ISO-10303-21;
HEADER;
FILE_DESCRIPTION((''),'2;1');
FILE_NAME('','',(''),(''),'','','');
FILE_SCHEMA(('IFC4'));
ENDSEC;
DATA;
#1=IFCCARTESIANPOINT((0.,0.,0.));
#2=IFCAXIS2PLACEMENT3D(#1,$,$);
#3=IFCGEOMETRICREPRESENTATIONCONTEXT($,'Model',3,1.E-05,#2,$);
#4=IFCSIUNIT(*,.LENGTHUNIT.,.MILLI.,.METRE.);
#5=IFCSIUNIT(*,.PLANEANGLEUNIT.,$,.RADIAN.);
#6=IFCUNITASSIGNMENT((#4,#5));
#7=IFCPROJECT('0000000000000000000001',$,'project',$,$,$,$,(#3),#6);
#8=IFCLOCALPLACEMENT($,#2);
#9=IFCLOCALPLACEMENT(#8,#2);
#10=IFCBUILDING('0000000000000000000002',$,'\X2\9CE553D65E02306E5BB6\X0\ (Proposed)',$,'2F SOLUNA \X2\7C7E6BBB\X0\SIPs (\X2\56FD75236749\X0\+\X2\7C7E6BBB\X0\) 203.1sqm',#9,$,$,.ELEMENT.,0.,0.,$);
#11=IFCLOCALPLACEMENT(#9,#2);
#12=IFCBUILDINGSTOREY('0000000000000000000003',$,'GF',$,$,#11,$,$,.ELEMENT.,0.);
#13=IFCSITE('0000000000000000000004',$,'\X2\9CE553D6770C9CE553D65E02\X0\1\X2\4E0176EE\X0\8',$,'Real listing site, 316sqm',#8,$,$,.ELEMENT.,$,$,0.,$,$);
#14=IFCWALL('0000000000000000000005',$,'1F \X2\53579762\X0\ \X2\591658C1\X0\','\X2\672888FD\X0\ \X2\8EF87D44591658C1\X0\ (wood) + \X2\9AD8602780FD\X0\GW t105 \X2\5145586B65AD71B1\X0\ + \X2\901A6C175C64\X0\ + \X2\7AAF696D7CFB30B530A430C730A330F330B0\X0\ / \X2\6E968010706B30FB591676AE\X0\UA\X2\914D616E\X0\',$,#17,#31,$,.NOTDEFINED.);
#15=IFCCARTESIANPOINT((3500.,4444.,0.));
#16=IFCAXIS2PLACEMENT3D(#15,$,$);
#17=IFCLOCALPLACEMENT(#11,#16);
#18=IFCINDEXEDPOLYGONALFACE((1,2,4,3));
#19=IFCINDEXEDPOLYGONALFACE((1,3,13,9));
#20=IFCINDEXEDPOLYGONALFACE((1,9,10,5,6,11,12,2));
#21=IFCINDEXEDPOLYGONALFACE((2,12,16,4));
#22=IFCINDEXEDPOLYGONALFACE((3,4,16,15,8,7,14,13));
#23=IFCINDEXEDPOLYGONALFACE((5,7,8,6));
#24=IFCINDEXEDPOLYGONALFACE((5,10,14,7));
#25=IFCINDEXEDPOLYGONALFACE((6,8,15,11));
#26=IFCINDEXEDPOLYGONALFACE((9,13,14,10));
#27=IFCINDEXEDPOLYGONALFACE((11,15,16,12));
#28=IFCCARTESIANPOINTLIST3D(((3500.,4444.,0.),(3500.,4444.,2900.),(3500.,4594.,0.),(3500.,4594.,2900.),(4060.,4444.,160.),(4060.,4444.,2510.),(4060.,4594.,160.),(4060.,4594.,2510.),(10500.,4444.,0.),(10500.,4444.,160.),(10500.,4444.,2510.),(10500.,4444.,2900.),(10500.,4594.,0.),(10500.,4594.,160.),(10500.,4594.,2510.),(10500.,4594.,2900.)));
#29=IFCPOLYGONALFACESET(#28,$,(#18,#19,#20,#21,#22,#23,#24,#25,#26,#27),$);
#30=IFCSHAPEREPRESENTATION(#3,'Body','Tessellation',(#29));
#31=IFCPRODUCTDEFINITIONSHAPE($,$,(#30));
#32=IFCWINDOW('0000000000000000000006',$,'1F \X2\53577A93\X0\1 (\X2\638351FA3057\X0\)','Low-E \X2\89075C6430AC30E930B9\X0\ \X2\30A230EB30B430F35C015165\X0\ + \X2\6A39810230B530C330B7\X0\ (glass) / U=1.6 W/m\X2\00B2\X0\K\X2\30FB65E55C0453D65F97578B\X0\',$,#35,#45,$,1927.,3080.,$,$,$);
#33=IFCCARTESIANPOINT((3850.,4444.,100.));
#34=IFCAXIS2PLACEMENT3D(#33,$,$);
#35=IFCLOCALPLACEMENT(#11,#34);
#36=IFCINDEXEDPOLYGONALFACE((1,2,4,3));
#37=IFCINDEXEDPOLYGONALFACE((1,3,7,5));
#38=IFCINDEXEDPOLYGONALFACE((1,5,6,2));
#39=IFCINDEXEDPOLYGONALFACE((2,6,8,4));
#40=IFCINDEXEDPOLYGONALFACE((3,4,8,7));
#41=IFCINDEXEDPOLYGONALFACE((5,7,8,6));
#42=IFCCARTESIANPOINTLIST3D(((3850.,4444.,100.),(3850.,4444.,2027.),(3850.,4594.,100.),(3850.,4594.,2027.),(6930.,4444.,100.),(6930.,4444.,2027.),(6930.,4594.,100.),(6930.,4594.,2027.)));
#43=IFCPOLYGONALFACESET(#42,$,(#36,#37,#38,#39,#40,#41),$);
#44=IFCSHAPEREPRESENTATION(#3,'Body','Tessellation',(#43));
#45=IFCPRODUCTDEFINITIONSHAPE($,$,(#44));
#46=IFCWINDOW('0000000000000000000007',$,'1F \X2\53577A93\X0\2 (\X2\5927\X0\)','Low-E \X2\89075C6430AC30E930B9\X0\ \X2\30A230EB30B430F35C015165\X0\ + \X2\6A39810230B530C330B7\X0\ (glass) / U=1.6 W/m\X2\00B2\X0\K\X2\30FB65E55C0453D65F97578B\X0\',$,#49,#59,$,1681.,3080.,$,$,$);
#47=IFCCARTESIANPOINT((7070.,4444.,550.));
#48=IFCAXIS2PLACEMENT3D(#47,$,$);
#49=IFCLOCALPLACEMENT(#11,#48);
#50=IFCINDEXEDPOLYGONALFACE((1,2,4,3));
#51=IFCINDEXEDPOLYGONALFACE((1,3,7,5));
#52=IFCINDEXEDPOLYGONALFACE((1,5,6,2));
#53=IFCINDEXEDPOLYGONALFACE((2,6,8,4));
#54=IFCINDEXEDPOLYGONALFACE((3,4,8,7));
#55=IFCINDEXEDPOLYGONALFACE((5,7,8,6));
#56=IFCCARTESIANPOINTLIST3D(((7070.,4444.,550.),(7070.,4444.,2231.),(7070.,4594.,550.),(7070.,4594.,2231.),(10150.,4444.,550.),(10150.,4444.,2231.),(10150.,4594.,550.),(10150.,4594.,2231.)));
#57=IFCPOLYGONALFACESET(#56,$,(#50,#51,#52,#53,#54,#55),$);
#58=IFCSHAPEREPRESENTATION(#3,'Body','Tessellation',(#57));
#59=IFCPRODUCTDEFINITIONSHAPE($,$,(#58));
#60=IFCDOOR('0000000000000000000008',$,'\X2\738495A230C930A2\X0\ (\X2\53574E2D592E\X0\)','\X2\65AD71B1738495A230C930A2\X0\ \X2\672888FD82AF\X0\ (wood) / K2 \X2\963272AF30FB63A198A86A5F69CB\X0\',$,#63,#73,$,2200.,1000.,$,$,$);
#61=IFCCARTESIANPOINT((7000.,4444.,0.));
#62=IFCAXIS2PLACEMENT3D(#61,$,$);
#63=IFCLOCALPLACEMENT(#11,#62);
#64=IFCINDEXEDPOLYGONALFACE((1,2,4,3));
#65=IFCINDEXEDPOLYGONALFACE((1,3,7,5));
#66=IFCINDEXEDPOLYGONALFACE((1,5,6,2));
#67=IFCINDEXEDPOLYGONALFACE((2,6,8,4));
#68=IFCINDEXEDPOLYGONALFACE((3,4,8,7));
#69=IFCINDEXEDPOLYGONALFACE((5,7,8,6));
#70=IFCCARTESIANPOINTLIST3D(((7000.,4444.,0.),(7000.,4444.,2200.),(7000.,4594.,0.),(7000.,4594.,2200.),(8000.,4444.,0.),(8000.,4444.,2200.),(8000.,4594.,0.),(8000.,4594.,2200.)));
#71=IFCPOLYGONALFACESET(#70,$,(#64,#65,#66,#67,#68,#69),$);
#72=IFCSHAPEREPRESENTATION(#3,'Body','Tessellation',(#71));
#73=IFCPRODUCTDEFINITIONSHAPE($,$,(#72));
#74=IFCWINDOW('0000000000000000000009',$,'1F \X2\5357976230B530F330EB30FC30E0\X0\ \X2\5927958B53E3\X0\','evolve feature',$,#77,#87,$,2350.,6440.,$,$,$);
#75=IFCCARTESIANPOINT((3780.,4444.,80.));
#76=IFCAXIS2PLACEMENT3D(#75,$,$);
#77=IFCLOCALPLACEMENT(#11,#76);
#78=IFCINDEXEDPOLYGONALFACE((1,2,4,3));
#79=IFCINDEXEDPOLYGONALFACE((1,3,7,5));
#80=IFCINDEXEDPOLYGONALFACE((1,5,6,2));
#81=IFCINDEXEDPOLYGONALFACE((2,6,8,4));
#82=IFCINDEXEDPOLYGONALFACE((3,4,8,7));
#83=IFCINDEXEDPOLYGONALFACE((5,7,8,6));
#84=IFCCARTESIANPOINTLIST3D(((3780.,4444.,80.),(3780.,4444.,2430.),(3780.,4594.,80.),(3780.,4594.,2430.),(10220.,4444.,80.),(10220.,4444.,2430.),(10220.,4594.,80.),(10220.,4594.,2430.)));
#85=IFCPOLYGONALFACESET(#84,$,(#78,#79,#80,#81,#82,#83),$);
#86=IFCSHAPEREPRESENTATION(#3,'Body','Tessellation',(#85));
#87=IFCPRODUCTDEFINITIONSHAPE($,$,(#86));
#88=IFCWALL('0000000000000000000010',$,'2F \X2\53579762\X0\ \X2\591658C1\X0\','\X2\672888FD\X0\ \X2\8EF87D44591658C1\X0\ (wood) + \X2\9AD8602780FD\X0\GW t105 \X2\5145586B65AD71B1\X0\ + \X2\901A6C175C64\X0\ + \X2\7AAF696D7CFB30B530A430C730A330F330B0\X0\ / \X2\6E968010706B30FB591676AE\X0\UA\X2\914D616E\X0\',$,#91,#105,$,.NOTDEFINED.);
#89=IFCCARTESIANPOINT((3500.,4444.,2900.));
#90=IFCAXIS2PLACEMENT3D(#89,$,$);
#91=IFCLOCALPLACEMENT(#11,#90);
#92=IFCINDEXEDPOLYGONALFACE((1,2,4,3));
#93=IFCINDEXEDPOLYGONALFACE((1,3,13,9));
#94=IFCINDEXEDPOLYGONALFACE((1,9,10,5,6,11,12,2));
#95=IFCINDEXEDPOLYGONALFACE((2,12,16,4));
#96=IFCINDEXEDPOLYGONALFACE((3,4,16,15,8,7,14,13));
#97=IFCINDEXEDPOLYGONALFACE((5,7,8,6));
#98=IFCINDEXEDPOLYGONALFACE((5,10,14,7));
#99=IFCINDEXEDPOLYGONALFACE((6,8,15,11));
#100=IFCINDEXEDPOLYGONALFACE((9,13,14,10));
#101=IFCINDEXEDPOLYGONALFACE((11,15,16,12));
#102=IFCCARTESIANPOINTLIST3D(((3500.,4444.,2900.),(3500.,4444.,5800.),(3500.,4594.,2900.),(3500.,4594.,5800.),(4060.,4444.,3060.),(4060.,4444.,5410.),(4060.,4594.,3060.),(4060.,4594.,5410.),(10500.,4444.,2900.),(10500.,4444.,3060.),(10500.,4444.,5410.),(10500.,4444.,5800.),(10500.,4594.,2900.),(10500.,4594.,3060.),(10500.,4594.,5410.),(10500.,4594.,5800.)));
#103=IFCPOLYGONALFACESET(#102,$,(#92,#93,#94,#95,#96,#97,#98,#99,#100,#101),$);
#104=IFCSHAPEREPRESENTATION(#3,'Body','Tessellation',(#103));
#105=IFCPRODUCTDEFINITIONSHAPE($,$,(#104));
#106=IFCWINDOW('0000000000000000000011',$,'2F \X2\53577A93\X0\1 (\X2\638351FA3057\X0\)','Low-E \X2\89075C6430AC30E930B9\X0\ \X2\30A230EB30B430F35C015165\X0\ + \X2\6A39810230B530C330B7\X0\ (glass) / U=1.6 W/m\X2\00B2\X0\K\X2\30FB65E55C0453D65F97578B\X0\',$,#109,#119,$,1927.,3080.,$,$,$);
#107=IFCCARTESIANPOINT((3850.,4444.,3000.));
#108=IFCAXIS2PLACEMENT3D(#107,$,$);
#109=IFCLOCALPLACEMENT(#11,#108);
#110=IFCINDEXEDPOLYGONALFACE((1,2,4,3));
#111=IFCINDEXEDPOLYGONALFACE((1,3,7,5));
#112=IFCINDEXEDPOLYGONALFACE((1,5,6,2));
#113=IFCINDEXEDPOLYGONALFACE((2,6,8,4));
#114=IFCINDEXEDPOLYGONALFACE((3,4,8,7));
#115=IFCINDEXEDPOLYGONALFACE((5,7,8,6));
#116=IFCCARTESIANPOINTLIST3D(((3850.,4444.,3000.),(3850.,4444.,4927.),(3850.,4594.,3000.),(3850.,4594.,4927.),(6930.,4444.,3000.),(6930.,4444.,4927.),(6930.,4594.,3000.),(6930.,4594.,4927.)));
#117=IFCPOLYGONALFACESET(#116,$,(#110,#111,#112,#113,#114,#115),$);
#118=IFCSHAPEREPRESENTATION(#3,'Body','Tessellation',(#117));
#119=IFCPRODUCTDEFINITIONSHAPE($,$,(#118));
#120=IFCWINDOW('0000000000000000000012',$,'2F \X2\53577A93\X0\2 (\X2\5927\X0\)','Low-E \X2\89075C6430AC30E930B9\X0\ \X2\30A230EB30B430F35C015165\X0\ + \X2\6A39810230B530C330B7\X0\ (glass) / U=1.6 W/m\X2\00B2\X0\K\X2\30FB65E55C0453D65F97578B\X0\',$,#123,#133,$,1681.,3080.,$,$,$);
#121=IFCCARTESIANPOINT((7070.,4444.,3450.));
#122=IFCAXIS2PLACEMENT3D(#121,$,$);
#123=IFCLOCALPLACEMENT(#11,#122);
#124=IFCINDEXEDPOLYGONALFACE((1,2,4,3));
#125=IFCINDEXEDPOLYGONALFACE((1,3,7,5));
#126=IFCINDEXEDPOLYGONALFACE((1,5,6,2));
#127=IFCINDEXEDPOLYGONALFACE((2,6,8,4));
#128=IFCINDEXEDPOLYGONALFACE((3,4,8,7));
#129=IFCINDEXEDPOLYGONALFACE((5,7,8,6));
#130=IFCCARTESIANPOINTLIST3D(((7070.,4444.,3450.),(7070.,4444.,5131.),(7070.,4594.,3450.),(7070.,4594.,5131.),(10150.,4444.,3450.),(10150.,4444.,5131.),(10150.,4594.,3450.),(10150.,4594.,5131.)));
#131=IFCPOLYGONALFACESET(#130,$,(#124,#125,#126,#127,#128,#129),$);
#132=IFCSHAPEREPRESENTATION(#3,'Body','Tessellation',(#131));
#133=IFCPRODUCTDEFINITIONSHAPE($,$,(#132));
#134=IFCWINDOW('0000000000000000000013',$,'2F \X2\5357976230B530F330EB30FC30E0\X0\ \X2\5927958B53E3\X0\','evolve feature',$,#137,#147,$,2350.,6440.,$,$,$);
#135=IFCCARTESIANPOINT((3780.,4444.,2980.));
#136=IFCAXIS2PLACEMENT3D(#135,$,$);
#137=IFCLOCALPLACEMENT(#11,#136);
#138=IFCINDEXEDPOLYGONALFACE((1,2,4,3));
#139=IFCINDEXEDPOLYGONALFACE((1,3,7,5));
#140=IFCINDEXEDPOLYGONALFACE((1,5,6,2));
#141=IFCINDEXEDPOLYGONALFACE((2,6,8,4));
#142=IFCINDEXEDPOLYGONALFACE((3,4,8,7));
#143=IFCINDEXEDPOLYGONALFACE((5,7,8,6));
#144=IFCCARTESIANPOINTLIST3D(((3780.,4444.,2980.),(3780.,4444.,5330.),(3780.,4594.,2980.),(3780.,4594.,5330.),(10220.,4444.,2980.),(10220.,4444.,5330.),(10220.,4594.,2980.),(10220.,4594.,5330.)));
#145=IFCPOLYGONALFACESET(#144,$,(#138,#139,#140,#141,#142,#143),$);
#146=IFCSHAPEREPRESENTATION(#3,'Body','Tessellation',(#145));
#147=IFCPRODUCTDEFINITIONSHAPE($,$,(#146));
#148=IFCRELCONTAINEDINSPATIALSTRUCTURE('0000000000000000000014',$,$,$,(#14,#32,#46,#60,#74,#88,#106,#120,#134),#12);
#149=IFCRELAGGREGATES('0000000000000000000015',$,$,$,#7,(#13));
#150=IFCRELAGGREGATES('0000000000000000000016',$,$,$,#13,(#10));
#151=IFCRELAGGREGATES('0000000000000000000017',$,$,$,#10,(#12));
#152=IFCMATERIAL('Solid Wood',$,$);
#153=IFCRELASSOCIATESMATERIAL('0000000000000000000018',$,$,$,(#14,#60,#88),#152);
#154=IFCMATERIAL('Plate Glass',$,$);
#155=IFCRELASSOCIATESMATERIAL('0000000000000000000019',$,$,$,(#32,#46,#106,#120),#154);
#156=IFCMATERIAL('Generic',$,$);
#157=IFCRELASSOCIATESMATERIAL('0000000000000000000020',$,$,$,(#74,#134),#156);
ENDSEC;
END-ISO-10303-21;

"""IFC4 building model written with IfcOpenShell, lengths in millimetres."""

from ifc_helpers import new_model, si_unit, frame, frame_2d, origin, place, context, project, spatial, rectangle, extrude, material, element, fill, save


model = new_model("IFC4")

# Units and contexts
model_context = context("Model", 3, precision=1e-05, world=origin())
ifc_project = project(units=[si_unit("LENGTHUNIT", "METRE", prefix="MILLI"), si_unit("PLANEANGLEUNIT", "RADIAN")], contexts=[model_context])

# Site, building, storey
site_placement = place(None, origin())
site = spatial("IfcSite", under=ifc_project, at=site_placement, Name="鳥取県鳥取市1丁目8", ObjectType="Real listing site, 316sqm", CompositionType="ELEMENT", RefElevation=0.0)
building_placement = place(site_placement, origin())
building = spatial("IfcBuilding", under=site, at=building_placement, Name="鳥取市の家 (Proposed)", ObjectType="2F SOLUNA 籾殻SIPs (国産杉+籾殻) 203.1sqm", CompositionType="ELEMENT", ElevationOfRefHeight=0.0, ElevationOfTerrain=0.0)
storey_placement = place(building_placement, origin())
storey = spatial("IfcBuildingStorey", under=building, at=storey_placement, Name="GF", CompositionType="ELEMENT", Elevation=0.0)

# Shared definitions
ifc_material_1 = material(Name="Solid Wood")

# Wall, openings, windows, door
wall_1_placement = place(storey_placement, frame((3500.0, 4444.0, 0.0)))
wall_1 = element("IfcWall", 1, at=wall_1_placement, inside=storey, material=ifc_material_1, Name="1F 南面 外壁", Description="木製 軸組外壁 (wood) + 高性能GW t105 充填断熱 + 通気層 + 窯業系サイディング / 準耐火・外皮UA配慮", PredefinedType="NOTDEFINED", context=model_context, shape_type="SweptSolid", body=[
    extrude(rectangle(XDim=7000.0, YDim=150.0, at=frame_2d((3500.0, 75.0))), frame((3500.0, 4444.0, 0.0)), (0.0, 0.0, 1.0), 2900.0),
])
opening_1_placement = place(storey_placement, frame((3850.0, 4444.0, 100.0)))
opening_1 = element("IfcOpeningElement", 2, at=opening_1_placement, cuts=wall_1, PredefinedType="NOTDEFINED", context=model_context, shape_type="SweptSolid", body=[
    extrude(rectangle(XDim=3080.0, YDim=150.0, at=frame_2d((1540.0, 75.0))), frame((3850.0, 4444.0, 100.0)), (0.0, 0.0, 1.0), 1927.0),
])
opening_2_placement = place(storey_placement, frame((7070.0, 4444.0, 550.0)))
opening_2 = element("IfcOpeningElement", 3, at=opening_2_placement, cuts=wall_1, PredefinedType="NOTDEFINED", context=model_context, shape_type="SweptSolid", body=[
    extrude(rectangle(XDim=3080.0, YDim=150.0, at=frame_2d((1540.0, 75.0))), frame((7070.0, 4444.0, 550.0)), (0.0, 0.0, 1.0), 1681.0),
])
opening_3_placement = place(storey_placement, frame((7000.0, 4444.0, 0.0)))
opening_3 = element("IfcOpeningElement", 4, at=opening_3_placement, cuts=wall_1, PredefinedType="NOTDEFINED", context=model_context, shape_type="SweptSolid", body=[
    extrude(rectangle(XDim=1000.0, YDim=150.0, at=frame_2d((500.0, 75.0))), frame((7000.0, 4444.0, 0.0)), (0.0, 0.0, 1.0), 2200.0),
])
opening_4_placement = place(storey_placement, frame((3780.0, 4444.0, 80.0)))
opening_4 = element("IfcOpeningElement", 5, at=opening_4_placement, cuts=wall_1, PredefinedType="NOTDEFINED", context=model_context, shape_type="SweptSolid", body=[
    extrude(rectangle(XDim=6440.0, YDim=150.0, at=frame_2d((3220.0, 75.0))), frame((3780.0, 4444.0, 80.0)), (0.0, 0.0, 1.0), 2350.0),
])
ifc_material_2 = material(Name="Plate Glass")
window_1_placement = place(storey_placement, frame((3850.0, 4444.0, 100.0)))
window_1 = element("IfcWindow", 6, at=window_1_placement, inside=storey, material=ifc_material_2, Name="1F 南窓1 (掃出し)", Description="Low-E 複層ガラス アルゴン封入 + 樹脂サッシ (glass) / U=1.6 W/m²K・日射取得型", OverallHeight=1927.0, OverallWidth=3080.0, context=model_context, shape_type="SweptSolid", body=[
    extrude(rectangle(XDim=3080.0, YDim=150.0, at=frame_2d((1540.0, 75.0))), frame((3850.0, 4444.0, 100.0)), (0.0, 0.0, 1.0), 1927.0),
])
fill(opening_1, window_1)
window_2_placement = place(storey_placement, frame((7070.0, 4444.0, 550.0)))
window_2 = element("IfcWindow", 7, at=window_2_placement, inside=storey, material=ifc_material_2, Name="1F 南窓2 (大)", Description="Low-E 複層ガラス アルゴン封入 + 樹脂サッシ (glass) / U=1.6 W/m²K・日射取得型", OverallHeight=1681.0, OverallWidth=3080.0, context=model_context, shape_type="SweptSolid", body=[
    extrude(rectangle(XDim=3080.0, YDim=150.0, at=frame_2d((1540.0, 75.0))), frame((7070.0, 4444.0, 550.0)), (0.0, 0.0, 1.0), 1681.0),
])
fill(opening_2, window_2)
door_placement = place(storey_placement, frame((7000.0, 4444.0, 0.0)))
door = element("IfcDoor", 8, at=door_placement, inside=storey, material=ifc_material_1, Name="玄関ドア (南中央)", Description="断熱玄関ドア 木製芯 (wood) / K2 防犯・採風機構", OverallHeight=2200.0, OverallWidth=1000.0, context=model_context, shape_type="SweptSolid", body=[
    extrude(rectangle(XDim=1000.0, YDim=150.0, at=frame_2d((500.0, 75.0))), frame((7000.0, 4444.0, 0.0)), (0.0, 0.0, 1.0), 2200.0),
])
fill(opening_3, door)
ifc_material_3 = material(Name="Generic")
window_3_placement = place(storey_placement, frame((3780.0, 4444.0, 80.0)))
window_3 = element("IfcWindow", 9, at=window_3_placement, inside=storey, material=ifc_material_3, Name="1F 南面サンルーム 大開口", Description="evolve feature", OverallHeight=2350.0, OverallWidth=6440.0, context=model_context, shape_type="SweptSolid", body=[
    extrude(rectangle(XDim=6440.0, YDim=150.0, at=frame_2d((3220.0, 75.0))), frame((3780.0, 4444.0, 80.0)), (0.0, 0.0, 1.0), 2350.0),
])
fill(opening_4, window_3)

# Wall, openings, windows
wall_2_placement = place(storey_placement, frame((3500.0, 4444.0, 2900.0)))
wall_2 = element("IfcWall", 10, at=wall_2_placement, inside=storey, material=ifc_material_1, Name="2F 南面 外壁", Description="木製 軸組外壁 (wood) + 高性能GW t105 充填断熱 + 通気層 + 窯業系サイディング / 準耐火・外皮UA配慮", PredefinedType="NOTDEFINED", context=model_context, shape_type="SweptSolid", body=[
    extrude(rectangle(XDim=7000.0, YDim=150.0, at=frame_2d((3500.0, 75.0))), frame((3500.0, 4444.0, 2900.0)), (0.0, 0.0, 1.0), 2900.0),
])
opening_5_placement = place(storey_placement, frame((3850.0, 4444.0, 3000.0)))
opening_5 = element("IfcOpeningElement", 11, at=opening_5_placement, cuts=wall_2, PredefinedType="NOTDEFINED", context=model_context, shape_type="SweptSolid", body=[
    extrude(rectangle(XDim=3080.0, YDim=150.0, at=frame_2d((1540.0, 75.0))), frame((3850.0, 4444.0, 3000.0)), (0.0, 0.0, 1.0), 1927.0),
])
opening_6_placement = place(storey_placement, frame((7070.0, 4444.0, 3450.0)))
opening_6 = element("IfcOpeningElement", 12, at=opening_6_placement, cuts=wall_2, PredefinedType="NOTDEFINED", context=model_context, shape_type="SweptSolid", body=[
    extrude(rectangle(XDim=3080.0, YDim=150.0, at=frame_2d((1540.0, 75.0))), frame((7070.0, 4444.0, 3450.0)), (0.0, 0.0, 1.0), 1681.0),
])
opening_7_placement = place(storey_placement, frame((3780.0, 4444.0, 2980.0)))
opening_7 = element("IfcOpeningElement", 13, at=opening_7_placement, cuts=wall_2, PredefinedType="NOTDEFINED", context=model_context, shape_type="SweptSolid", body=[
    extrude(rectangle(XDim=6440.0, YDim=150.0, at=frame_2d((3220.0, 75.0))), frame((3780.0, 4444.0, 2980.0)), (0.0, 0.0, 1.0), 2350.0),
])
window_4_placement = place(storey_placement, frame((3850.0, 4444.0, 3000.0)))
window_4 = element("IfcWindow", 14, at=window_4_placement, inside=storey, material=ifc_material_2, Name="2F 南窓1 (掃出し)", Description="Low-E 複層ガラス アルゴン封入 + 樹脂サッシ (glass) / U=1.6 W/m²K・日射取得型", OverallHeight=1927.0, OverallWidth=3080.0, context=model_context, shape_type="SweptSolid", body=[
    extrude(rectangle(XDim=3080.0, YDim=150.0, at=frame_2d((1540.0, 75.0))), frame((3850.0, 4444.0, 3000.0)), (0.0, 0.0, 1.0), 1927.0),
])
fill(opening_5, window_4)
window_5_placement = place(storey_placement, frame((7070.0, 4444.0, 3450.0)))
window_5 = element("IfcWindow", 15, at=window_5_placement, inside=storey, material=ifc_material_2, Name="2F 南窓2 (大)", Description="Low-E 複層ガラス アルゴン封入 + 樹脂サッシ (glass) / U=1.6 W/m²K・日射取得型", OverallHeight=1681.0, OverallWidth=3080.0, context=model_context, shape_type="SweptSolid", body=[
    extrude(rectangle(XDim=3080.0, YDim=150.0, at=frame_2d((1540.0, 75.0))), frame((7070.0, 4444.0, 3450.0)), (0.0, 0.0, 1.0), 1681.0),
])
fill(opening_6, window_5)
window_6_placement = place(storey_placement, frame((3780.0, 4444.0, 2980.0)))
window_6 = element("IfcWindow", 16, at=window_6_placement, inside=storey, material=ifc_material_3, Name="2F 南面サンルーム 大開口", Description="evolve feature", OverallHeight=2350.0, OverallWidth=6440.0, context=model_context, shape_type="SweptSolid", body=[
    extrude(rectangle(XDim=6440.0, YDim=150.0, at=frame_2d((3220.0, 75.0))), frame((3780.0, 4444.0, 2980.0)), (0.0, 0.0, 1.0), 2350.0),
])
fill(opening_7, window_6)

save(model, "model.ifc")
